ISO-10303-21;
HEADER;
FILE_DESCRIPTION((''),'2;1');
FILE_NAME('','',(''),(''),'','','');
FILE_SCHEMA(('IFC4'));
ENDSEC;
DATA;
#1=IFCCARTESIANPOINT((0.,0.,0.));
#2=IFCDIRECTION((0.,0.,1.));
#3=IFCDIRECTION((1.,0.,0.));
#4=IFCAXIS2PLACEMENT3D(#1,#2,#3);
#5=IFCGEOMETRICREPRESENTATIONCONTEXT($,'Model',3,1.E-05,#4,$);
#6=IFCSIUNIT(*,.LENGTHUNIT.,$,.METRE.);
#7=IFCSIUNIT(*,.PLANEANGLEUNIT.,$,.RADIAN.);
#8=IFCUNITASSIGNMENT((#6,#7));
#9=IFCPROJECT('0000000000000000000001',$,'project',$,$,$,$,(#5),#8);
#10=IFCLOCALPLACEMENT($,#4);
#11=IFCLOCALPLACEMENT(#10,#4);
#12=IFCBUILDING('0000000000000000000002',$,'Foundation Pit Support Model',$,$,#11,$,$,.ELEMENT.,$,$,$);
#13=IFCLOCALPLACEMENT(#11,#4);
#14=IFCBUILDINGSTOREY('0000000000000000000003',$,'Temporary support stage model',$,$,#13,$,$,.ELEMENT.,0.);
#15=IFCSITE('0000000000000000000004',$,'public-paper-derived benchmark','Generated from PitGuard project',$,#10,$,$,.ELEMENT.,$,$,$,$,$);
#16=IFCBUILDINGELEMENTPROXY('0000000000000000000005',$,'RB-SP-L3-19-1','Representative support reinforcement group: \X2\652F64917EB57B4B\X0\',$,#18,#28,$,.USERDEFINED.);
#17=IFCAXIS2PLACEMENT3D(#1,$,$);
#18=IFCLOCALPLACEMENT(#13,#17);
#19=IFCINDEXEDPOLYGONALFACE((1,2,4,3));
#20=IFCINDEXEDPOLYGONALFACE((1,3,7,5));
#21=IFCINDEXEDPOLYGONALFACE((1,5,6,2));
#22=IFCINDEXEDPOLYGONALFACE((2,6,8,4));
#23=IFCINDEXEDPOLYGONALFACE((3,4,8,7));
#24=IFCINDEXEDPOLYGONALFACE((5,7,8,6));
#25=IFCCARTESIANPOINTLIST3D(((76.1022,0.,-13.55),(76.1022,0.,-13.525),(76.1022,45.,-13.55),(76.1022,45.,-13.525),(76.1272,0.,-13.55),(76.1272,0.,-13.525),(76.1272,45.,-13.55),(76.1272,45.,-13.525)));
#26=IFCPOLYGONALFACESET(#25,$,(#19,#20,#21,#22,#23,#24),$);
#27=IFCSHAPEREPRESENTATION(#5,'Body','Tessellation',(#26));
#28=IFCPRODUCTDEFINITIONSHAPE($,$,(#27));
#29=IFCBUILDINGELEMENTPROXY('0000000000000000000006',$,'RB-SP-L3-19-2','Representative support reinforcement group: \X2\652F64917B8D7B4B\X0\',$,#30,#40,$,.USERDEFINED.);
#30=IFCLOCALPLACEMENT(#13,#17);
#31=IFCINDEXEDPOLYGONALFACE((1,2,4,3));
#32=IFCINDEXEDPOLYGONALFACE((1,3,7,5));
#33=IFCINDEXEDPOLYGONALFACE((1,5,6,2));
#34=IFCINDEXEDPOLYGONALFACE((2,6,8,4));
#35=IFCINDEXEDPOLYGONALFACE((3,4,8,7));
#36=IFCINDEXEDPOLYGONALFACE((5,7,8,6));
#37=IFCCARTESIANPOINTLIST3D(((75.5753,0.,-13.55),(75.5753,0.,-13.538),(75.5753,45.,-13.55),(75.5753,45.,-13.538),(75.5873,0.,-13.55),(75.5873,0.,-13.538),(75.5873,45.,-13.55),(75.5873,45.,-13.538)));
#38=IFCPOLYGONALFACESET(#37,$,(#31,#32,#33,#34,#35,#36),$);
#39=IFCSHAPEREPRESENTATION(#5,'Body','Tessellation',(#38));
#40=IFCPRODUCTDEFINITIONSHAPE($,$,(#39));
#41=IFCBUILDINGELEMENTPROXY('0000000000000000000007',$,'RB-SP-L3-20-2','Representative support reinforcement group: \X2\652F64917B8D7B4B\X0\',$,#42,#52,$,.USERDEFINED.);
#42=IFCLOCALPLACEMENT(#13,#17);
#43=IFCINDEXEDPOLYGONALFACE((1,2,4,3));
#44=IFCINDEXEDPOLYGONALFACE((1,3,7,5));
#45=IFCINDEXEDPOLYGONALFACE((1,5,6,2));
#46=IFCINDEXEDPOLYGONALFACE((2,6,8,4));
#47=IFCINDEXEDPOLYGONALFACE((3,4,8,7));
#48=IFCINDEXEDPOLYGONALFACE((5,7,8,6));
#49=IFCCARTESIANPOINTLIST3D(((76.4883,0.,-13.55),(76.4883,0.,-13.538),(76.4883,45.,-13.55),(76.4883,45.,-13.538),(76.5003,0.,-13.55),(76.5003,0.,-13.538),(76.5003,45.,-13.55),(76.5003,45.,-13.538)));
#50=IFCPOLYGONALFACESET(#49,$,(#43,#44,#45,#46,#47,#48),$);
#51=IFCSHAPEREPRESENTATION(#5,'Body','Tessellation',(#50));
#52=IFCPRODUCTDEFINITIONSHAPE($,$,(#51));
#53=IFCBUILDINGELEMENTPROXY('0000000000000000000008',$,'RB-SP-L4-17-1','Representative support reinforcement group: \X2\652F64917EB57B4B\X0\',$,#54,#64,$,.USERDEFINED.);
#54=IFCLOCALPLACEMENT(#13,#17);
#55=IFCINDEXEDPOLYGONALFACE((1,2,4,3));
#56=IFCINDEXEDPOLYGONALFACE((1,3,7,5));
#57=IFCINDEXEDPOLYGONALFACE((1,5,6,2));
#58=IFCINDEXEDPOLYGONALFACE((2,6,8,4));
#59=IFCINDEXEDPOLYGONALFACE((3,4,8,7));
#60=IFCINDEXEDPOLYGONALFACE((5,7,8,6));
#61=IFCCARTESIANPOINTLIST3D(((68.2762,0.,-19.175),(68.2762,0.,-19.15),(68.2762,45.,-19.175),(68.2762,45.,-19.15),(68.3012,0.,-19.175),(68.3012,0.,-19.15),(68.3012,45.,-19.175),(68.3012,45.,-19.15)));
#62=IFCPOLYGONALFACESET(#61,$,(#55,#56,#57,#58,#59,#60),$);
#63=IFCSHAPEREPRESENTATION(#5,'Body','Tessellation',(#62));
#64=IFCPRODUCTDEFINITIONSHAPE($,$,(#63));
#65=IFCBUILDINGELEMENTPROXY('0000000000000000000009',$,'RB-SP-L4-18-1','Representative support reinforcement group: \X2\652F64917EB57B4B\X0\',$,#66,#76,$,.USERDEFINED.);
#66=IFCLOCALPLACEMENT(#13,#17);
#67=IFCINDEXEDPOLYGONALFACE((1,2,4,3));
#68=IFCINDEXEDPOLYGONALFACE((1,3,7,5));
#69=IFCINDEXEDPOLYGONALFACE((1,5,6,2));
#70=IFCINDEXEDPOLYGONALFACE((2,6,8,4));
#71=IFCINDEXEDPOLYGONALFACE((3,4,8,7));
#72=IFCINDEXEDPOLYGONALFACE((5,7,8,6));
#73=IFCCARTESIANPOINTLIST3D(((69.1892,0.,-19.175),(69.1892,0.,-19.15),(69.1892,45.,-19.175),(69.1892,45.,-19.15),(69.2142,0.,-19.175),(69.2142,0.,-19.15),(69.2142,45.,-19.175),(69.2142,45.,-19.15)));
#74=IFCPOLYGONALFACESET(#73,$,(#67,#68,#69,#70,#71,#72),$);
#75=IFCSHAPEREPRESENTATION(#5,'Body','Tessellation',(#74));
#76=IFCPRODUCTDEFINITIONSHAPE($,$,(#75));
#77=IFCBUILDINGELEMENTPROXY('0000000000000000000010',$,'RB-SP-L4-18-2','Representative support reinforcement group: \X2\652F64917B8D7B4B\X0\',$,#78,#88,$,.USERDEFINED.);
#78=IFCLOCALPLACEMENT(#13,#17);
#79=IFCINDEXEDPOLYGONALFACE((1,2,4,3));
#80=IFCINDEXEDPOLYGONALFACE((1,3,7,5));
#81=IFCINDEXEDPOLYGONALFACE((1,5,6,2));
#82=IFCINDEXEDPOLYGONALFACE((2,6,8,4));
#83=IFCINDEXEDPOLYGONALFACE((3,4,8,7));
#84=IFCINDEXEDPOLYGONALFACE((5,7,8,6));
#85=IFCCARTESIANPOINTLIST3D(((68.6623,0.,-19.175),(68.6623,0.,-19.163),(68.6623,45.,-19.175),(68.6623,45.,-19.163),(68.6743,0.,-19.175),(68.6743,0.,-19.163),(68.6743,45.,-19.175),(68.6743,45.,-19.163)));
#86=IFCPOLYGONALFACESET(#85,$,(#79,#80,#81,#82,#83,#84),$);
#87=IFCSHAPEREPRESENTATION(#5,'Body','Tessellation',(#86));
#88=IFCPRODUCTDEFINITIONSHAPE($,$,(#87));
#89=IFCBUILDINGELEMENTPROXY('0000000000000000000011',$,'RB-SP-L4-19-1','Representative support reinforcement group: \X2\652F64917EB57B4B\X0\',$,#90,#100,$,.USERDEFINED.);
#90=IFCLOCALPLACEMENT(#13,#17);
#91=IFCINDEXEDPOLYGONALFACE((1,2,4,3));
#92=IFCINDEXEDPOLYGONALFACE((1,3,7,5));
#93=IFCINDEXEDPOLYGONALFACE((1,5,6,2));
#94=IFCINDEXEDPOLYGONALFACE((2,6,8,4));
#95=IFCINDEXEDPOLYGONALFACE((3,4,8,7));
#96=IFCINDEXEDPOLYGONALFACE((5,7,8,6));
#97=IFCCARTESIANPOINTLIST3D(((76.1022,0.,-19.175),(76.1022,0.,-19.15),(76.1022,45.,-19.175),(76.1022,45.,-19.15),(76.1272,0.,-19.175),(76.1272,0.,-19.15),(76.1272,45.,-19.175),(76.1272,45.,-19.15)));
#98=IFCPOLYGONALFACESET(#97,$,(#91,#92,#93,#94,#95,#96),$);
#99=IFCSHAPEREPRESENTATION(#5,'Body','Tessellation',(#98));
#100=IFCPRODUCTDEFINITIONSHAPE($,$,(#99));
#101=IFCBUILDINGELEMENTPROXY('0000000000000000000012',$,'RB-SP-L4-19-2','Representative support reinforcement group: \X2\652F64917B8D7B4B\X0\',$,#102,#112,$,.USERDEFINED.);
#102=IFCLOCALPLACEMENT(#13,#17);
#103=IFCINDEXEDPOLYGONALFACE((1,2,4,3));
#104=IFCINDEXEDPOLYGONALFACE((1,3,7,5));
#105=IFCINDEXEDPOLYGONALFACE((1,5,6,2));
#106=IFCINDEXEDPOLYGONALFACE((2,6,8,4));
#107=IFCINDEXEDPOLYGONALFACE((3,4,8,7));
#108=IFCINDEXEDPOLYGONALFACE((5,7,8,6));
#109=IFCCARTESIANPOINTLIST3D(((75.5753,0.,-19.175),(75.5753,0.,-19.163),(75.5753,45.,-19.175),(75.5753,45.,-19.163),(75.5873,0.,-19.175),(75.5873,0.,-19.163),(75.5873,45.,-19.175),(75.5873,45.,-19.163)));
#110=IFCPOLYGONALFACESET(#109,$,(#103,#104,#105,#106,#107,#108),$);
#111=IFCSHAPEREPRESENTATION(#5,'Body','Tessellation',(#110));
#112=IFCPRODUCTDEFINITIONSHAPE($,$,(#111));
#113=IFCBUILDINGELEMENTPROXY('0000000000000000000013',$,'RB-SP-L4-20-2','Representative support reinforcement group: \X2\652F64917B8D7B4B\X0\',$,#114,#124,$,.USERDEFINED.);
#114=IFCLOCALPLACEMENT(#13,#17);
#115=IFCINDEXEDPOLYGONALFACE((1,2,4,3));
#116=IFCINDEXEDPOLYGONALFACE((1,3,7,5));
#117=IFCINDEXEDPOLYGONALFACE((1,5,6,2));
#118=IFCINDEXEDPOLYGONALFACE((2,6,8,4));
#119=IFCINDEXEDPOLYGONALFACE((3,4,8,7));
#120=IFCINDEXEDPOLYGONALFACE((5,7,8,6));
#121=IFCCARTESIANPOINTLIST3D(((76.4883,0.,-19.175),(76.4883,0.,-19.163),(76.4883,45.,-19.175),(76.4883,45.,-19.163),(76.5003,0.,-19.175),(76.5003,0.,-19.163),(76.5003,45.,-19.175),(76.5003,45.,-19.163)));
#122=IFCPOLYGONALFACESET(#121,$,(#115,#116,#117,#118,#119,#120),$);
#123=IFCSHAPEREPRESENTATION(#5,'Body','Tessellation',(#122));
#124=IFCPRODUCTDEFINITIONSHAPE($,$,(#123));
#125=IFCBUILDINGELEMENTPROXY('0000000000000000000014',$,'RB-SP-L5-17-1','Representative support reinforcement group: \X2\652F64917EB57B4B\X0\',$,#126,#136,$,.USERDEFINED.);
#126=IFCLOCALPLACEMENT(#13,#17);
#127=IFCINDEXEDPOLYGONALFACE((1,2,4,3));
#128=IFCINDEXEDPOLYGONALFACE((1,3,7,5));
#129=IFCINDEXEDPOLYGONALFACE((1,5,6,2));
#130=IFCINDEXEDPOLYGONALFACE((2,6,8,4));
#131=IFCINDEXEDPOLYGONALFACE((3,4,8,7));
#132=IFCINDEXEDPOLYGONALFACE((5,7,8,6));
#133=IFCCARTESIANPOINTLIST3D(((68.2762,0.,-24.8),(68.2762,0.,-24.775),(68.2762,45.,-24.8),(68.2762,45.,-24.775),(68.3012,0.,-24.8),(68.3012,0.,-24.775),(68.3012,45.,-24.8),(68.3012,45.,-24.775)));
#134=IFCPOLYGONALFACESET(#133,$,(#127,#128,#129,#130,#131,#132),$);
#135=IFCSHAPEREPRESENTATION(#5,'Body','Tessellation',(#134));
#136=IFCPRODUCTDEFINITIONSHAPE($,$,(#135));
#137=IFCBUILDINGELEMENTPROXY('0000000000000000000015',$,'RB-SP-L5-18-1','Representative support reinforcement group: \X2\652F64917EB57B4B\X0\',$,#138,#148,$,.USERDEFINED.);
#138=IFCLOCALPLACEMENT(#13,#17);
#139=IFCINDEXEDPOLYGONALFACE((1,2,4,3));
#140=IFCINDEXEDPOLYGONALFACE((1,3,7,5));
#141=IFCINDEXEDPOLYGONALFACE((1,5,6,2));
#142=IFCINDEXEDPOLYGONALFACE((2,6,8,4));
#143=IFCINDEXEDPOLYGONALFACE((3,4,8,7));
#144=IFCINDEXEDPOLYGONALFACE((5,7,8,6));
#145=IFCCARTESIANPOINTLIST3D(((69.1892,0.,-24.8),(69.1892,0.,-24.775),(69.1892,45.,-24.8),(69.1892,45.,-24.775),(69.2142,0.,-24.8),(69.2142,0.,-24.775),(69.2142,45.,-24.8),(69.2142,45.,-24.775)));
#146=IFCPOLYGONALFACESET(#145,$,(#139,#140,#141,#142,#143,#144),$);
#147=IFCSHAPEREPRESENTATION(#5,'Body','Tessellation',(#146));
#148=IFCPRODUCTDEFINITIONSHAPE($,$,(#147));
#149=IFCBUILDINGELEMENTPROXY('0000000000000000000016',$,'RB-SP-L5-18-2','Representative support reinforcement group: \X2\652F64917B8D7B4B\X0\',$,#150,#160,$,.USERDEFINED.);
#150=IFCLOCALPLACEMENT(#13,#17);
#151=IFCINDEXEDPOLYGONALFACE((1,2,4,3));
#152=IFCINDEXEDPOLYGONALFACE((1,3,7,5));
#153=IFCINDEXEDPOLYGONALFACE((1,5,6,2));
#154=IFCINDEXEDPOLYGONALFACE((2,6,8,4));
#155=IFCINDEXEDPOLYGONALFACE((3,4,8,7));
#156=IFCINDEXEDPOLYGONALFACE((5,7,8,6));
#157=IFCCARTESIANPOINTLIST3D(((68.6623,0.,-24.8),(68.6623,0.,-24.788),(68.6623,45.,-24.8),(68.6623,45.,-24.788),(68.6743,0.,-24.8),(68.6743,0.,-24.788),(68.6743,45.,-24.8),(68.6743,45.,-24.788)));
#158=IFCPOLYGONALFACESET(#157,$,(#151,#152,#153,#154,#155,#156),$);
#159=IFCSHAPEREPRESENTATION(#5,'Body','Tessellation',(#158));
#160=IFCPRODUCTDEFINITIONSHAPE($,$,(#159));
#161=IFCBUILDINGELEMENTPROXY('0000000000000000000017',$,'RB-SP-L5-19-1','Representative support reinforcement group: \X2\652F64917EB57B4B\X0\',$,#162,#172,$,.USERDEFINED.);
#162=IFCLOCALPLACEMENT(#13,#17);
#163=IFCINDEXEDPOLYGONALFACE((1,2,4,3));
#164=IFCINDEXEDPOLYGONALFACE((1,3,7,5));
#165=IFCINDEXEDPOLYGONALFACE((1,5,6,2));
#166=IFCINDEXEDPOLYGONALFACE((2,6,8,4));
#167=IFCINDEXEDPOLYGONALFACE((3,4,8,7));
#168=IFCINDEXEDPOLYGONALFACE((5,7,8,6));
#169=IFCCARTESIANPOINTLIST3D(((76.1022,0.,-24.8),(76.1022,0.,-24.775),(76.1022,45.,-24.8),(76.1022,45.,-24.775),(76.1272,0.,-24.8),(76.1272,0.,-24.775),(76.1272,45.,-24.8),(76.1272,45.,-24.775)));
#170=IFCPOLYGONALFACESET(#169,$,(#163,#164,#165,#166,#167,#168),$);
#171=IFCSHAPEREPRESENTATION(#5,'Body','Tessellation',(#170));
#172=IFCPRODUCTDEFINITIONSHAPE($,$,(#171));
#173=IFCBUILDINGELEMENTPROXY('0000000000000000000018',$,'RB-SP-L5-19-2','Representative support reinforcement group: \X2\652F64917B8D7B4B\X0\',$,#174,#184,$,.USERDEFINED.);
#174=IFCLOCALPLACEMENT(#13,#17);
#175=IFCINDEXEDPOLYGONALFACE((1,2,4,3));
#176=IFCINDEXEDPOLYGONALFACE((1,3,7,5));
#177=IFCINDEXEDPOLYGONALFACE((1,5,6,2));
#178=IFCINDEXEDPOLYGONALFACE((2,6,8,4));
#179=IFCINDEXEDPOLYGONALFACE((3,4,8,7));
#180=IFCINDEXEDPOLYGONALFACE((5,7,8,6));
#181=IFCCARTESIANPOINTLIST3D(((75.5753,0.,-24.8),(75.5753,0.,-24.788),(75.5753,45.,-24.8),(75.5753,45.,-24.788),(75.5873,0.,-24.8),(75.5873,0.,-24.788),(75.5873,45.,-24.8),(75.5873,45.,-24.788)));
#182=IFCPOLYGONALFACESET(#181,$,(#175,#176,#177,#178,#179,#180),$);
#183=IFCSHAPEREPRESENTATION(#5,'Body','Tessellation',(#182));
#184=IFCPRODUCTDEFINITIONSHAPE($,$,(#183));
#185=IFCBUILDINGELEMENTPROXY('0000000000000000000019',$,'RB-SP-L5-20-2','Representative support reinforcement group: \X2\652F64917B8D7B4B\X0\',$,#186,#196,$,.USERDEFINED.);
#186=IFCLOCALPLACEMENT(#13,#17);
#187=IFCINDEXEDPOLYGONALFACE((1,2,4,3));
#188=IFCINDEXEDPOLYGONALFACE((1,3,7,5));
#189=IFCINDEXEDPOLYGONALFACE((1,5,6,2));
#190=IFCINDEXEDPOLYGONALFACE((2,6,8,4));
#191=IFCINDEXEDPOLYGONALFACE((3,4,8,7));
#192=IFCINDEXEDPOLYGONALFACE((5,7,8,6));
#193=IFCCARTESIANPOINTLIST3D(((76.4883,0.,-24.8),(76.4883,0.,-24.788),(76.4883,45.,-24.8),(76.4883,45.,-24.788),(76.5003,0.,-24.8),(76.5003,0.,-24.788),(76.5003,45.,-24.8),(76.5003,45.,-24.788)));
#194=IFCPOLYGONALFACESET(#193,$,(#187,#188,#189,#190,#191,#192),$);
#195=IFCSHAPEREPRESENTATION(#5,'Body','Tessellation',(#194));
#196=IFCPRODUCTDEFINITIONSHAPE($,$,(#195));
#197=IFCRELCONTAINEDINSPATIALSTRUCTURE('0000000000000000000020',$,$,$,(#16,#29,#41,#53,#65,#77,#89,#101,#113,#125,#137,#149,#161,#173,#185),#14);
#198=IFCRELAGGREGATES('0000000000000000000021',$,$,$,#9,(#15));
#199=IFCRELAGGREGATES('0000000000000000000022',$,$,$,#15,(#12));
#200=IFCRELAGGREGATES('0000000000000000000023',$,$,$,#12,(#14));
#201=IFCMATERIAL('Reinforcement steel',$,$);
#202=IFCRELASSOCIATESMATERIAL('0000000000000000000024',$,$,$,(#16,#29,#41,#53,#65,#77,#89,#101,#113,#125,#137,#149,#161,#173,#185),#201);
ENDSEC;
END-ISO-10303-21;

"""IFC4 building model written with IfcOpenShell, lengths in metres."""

from ifc_helpers import new_model, si_unit, frame, origin_with_axes, origin_2d, place, context, project, spatial, rectangle, extrude, material, element, save


model = new_model("IFC4")

# Units and contexts
model_context = context("Model", 3, precision=1e-05, world=origin_with_axes())
ifc_project = project(units=[si_unit("LENGTHUNIT", "METRE"), si_unit("PLANEANGLEUNIT", "RADIAN")], contexts=[model_context])

# Site, building, storey
site_placement = place(None, origin_with_axes())
site = spatial("IfcSite", under=ifc_project, at=site_placement, Name="public-paper-derived benchmark", Description="Generated from PitGuard project", CompositionType="ELEMENT")
building_placement = place(site_placement, origin_with_axes())
building = spatial("IfcBuilding", under=site, at=building_placement, Name="Foundation Pit Support Model", CompositionType="ELEMENT")
storey_placement = place(building_placement, origin_with_axes())
storey = spatial("IfcBuildingStorey", under=building, at=storey_placement, Name="Temporary support stage model", CompositionType="ELEMENT", Elevation=0.0)

# Building element proxies
ifc_material_1 = material(Name="Reinforcement steel")
proxy_1_placement = place(storey_placement, frame((76.1147, 22.5, -13.55), z_axis=(0.0, 0.0, 1.0), x_axis=(0.0, 1.0, 0.0)))
element("IfcBuildingElementProxy", 1, at=proxy_1_placement, inside=storey, material=ifc_material_1, Name="RB-SP-L3-19-1", Description="Representative support reinforcement group: 支撑纵筋", PredefinedType="USERDEFINED", context=model_context, shape_type="SweptSolid", body=[
    extrude(rectangle(XDim=45.0, YDim=0.025, at=origin_2d()), origin_with_axes(), (0.0, 0.0, 1.0), 0.025),
])
for number, where, z_axis, x_axis, name in (
    (2, (75.5813, 22.5, -13.55), (0.0, 0.0, 1.0), (0.0, 1.0, 0.0), "RB-SP-L3-19-2"),
    (3, (76.4943, 22.5, -13.55), (0.0, 0.0, 1.0), (0.0, 1.0, 0.0), "RB-SP-L3-20-2"),
):
    element("IfcBuildingElementProxy", number, at=place(storey_placement, frame(where, z_axis=z_axis, x_axis=x_axis)), inside=storey, material=ifc_material_1, Name=name, Description="Representative support reinforcement group: 支撑箍筋", PredefinedType="USERDEFINED", context=model_context, shape_type="SweptSolid", body=[
        extrude(rectangle(XDim=45.0, YDim=0.012, at=origin_2d()), origin_with_axes(), (0.0, 0.0, 1.0), 0.012),
    ])
for number, where, z_axis, x_axis, name in (
    (4, (68.2887, 22.5, -19.175), (0.0, 0.0, 1.0), (0.0, 1.0, 0.0), "RB-SP-L4-17-1"),
    (5, (69.2017, 22.5, -19.175), (0.0, 0.0, 1.0), (0.0, 1.0, 0.0), "RB-SP-L4-18-1"),
):
    element("IfcBuildingElementProxy", number, at=place(storey_placement, frame(where, z_axis=z_axis, x_axis=x_axis)), inside=storey, material=ifc_material_1, Name=name, Description="Representative support reinforcement group: 支撑纵筋", PredefinedType="USERDEFINED", context=model_context, shape_type="SweptSolid", body=[
        extrude(rectangle(XDim=45.0, YDim=0.025, at=origin_2d()), origin_with_axes(), (0.0, 0.0, 1.0), 0.025),
    ])
proxy_2_placement = place(storey_placement, frame((68.6683, 22.5, -19.175), z_axis=(0.0, 0.0, 1.0), x_axis=(0.0, 1.0, 0.0)))
element("IfcBuildingElementProxy", 6, at=proxy_2_placement, inside=storey, material=ifc_material_1, Name="RB-SP-L4-18-2", Description="Representative support reinforcement group: 支撑箍筋", PredefinedType="USERDEFINED", context=model_context, shape_type="SweptSolid", body=[
    extrude(rectangle(XDim=45.0, YDim=0.012, at=origin_2d()), origin_with_axes(), (0.0, 0.0, 1.0), 0.012),
])
proxy_3_placement = place(storey_placement, frame((76.1147, 22.5, -19.175), z_axis=(0.0, 0.0, 1.0), x_axis=(0.0, 1.0, 0.0)))
element("IfcBuildingElementProxy", 7, at=proxy_3_placement, inside=storey, material=ifc_material_1, Name="RB-SP-L4-19-1", Description="Representative support reinforcement group: 支撑纵筋", PredefinedType="USERDEFINED", context=model_context, shape_type="SweptSolid", body=[
    extrude(rectangle(XDim=45.0, YDim=0.025, at=origin_2d()), origin_with_axes(), (0.0, 0.0, 1.0), 0.025),
])
for number, where, z_axis, x_axis, name in (
    (8, (75.5813, 22.5, -19.175), (0.0, 0.0, 1.0), (0.0, 1.0, 0.0), "RB-SP-L4-19-2"),
    (9, (76.4943, 22.5, -19.175), (0.0, 0.0, 1.0), (0.0, 1.0, 0.0), "RB-SP-L4-20-2"),
):
    element("IfcBuildingElementProxy", number, at=place(storey_placement, frame(where, z_axis=z_axis, x_axis=x_axis)), inside=storey, material=ifc_material_1, Name=name, Description="Representative support reinforcement group: 支撑箍筋", PredefinedType="USERDEFINED", context=model_context, shape_type="SweptSolid", body=[
        extrude(rectangle(XDim=45.0, YDim=0.012, at=origin_2d()), origin_with_axes(), (0.0, 0.0, 1.0), 0.012),
    ])
for number, where, z_axis, x_axis, name in (
    (10, (68.2887, 22.5, -24.8), (0.0, 0.0, 1.0), (0.0, 1.0, 0.0), "RB-SP-L5-17-1"),
    (11, (69.2017, 22.5, -24.8), (0.0, 0.0, 1.0), (0.0, 1.0, 0.0), "RB-SP-L5-18-1"),
):
    element("IfcBuildingElementProxy", number, at=place(storey_placement, frame(where, z_axis=z_axis, x_axis=x_axis)), inside=storey, material=ifc_material_1, Name=name, Description="Representative support reinforcement group: 支撑纵筋", PredefinedType="USERDEFINED", context=model_context, shape_type="SweptSolid", body=[
        extrude(rectangle(XDim=45.0, YDim=0.025, at=origin_2d()), origin_with_axes(), (0.0, 0.0, 1.0), 0.025),
    ])
proxy_4_placement = place(storey_placement, frame((68.6683, 22.5, -24.8), z_axis=(0.0, 0.0, 1.0), x_axis=(0.0, 1.0, 0.0)))
element("IfcBuildingElementProxy", 12, at=proxy_4_placement, inside=storey, material=ifc_material_1, Name="RB-SP-L5-18-2", Description="Representative support reinforcement group: 支撑箍筋", PredefinedType="USERDEFINED", context=model_context, shape_type="SweptSolid", body=[
    extrude(rectangle(XDim=45.0, YDim=0.012, at=origin_2d()), origin_with_axes(), (0.0, 0.0, 1.0), 0.012),
])
proxy_5_placement = place(storey_placement, frame((76.1147, 22.5, -24.8), z_axis=(0.0, 0.0, 1.0), x_axis=(0.0, 1.0, 0.0)))
element("IfcBuildingElementProxy", 13, at=proxy_5_placement, inside=storey, material=ifc_material_1, Name="RB-SP-L5-19-1", Description="Representative support reinforcement group: 支撑纵筋", PredefinedType="USERDEFINED", context=model_context, shape_type="SweptSolid", body=[
    extrude(rectangle(XDim=45.0, YDim=0.025, at=origin_2d()), origin_with_axes(), (0.0, 0.0, 1.0), 0.025),
])
for number, where, z_axis, x_axis, name in (
    (14, (75.5813, 22.5, -24.8), (0.0, 0.0, 1.0), (0.0, 1.0, 0.0), "RB-SP-L5-19-2"),
    (15, (76.4943, 22.5, -24.8), (0.0, 0.0, 1.0), (0.0, 1.0, 0.0), "RB-SP-L5-20-2"),
):
    element("IfcBuildingElementProxy", number, at=place(storey_placement, frame(where, z_axis=z_axis, x_axis=x_axis)), inside=storey, material=ifc_material_1, Name=name, Description="Representative support reinforcement group: 支撑箍筋", PredefinedType="USERDEFINED", context=model_context, shape_type="SweptSolid", body=[
        extrude(rectangle(XDim=45.0, YDim=0.012, at=origin_2d()), origin_with_axes(), (0.0, 0.0, 1.0), 0.012),
    ])

save(model, "model.ifc")
